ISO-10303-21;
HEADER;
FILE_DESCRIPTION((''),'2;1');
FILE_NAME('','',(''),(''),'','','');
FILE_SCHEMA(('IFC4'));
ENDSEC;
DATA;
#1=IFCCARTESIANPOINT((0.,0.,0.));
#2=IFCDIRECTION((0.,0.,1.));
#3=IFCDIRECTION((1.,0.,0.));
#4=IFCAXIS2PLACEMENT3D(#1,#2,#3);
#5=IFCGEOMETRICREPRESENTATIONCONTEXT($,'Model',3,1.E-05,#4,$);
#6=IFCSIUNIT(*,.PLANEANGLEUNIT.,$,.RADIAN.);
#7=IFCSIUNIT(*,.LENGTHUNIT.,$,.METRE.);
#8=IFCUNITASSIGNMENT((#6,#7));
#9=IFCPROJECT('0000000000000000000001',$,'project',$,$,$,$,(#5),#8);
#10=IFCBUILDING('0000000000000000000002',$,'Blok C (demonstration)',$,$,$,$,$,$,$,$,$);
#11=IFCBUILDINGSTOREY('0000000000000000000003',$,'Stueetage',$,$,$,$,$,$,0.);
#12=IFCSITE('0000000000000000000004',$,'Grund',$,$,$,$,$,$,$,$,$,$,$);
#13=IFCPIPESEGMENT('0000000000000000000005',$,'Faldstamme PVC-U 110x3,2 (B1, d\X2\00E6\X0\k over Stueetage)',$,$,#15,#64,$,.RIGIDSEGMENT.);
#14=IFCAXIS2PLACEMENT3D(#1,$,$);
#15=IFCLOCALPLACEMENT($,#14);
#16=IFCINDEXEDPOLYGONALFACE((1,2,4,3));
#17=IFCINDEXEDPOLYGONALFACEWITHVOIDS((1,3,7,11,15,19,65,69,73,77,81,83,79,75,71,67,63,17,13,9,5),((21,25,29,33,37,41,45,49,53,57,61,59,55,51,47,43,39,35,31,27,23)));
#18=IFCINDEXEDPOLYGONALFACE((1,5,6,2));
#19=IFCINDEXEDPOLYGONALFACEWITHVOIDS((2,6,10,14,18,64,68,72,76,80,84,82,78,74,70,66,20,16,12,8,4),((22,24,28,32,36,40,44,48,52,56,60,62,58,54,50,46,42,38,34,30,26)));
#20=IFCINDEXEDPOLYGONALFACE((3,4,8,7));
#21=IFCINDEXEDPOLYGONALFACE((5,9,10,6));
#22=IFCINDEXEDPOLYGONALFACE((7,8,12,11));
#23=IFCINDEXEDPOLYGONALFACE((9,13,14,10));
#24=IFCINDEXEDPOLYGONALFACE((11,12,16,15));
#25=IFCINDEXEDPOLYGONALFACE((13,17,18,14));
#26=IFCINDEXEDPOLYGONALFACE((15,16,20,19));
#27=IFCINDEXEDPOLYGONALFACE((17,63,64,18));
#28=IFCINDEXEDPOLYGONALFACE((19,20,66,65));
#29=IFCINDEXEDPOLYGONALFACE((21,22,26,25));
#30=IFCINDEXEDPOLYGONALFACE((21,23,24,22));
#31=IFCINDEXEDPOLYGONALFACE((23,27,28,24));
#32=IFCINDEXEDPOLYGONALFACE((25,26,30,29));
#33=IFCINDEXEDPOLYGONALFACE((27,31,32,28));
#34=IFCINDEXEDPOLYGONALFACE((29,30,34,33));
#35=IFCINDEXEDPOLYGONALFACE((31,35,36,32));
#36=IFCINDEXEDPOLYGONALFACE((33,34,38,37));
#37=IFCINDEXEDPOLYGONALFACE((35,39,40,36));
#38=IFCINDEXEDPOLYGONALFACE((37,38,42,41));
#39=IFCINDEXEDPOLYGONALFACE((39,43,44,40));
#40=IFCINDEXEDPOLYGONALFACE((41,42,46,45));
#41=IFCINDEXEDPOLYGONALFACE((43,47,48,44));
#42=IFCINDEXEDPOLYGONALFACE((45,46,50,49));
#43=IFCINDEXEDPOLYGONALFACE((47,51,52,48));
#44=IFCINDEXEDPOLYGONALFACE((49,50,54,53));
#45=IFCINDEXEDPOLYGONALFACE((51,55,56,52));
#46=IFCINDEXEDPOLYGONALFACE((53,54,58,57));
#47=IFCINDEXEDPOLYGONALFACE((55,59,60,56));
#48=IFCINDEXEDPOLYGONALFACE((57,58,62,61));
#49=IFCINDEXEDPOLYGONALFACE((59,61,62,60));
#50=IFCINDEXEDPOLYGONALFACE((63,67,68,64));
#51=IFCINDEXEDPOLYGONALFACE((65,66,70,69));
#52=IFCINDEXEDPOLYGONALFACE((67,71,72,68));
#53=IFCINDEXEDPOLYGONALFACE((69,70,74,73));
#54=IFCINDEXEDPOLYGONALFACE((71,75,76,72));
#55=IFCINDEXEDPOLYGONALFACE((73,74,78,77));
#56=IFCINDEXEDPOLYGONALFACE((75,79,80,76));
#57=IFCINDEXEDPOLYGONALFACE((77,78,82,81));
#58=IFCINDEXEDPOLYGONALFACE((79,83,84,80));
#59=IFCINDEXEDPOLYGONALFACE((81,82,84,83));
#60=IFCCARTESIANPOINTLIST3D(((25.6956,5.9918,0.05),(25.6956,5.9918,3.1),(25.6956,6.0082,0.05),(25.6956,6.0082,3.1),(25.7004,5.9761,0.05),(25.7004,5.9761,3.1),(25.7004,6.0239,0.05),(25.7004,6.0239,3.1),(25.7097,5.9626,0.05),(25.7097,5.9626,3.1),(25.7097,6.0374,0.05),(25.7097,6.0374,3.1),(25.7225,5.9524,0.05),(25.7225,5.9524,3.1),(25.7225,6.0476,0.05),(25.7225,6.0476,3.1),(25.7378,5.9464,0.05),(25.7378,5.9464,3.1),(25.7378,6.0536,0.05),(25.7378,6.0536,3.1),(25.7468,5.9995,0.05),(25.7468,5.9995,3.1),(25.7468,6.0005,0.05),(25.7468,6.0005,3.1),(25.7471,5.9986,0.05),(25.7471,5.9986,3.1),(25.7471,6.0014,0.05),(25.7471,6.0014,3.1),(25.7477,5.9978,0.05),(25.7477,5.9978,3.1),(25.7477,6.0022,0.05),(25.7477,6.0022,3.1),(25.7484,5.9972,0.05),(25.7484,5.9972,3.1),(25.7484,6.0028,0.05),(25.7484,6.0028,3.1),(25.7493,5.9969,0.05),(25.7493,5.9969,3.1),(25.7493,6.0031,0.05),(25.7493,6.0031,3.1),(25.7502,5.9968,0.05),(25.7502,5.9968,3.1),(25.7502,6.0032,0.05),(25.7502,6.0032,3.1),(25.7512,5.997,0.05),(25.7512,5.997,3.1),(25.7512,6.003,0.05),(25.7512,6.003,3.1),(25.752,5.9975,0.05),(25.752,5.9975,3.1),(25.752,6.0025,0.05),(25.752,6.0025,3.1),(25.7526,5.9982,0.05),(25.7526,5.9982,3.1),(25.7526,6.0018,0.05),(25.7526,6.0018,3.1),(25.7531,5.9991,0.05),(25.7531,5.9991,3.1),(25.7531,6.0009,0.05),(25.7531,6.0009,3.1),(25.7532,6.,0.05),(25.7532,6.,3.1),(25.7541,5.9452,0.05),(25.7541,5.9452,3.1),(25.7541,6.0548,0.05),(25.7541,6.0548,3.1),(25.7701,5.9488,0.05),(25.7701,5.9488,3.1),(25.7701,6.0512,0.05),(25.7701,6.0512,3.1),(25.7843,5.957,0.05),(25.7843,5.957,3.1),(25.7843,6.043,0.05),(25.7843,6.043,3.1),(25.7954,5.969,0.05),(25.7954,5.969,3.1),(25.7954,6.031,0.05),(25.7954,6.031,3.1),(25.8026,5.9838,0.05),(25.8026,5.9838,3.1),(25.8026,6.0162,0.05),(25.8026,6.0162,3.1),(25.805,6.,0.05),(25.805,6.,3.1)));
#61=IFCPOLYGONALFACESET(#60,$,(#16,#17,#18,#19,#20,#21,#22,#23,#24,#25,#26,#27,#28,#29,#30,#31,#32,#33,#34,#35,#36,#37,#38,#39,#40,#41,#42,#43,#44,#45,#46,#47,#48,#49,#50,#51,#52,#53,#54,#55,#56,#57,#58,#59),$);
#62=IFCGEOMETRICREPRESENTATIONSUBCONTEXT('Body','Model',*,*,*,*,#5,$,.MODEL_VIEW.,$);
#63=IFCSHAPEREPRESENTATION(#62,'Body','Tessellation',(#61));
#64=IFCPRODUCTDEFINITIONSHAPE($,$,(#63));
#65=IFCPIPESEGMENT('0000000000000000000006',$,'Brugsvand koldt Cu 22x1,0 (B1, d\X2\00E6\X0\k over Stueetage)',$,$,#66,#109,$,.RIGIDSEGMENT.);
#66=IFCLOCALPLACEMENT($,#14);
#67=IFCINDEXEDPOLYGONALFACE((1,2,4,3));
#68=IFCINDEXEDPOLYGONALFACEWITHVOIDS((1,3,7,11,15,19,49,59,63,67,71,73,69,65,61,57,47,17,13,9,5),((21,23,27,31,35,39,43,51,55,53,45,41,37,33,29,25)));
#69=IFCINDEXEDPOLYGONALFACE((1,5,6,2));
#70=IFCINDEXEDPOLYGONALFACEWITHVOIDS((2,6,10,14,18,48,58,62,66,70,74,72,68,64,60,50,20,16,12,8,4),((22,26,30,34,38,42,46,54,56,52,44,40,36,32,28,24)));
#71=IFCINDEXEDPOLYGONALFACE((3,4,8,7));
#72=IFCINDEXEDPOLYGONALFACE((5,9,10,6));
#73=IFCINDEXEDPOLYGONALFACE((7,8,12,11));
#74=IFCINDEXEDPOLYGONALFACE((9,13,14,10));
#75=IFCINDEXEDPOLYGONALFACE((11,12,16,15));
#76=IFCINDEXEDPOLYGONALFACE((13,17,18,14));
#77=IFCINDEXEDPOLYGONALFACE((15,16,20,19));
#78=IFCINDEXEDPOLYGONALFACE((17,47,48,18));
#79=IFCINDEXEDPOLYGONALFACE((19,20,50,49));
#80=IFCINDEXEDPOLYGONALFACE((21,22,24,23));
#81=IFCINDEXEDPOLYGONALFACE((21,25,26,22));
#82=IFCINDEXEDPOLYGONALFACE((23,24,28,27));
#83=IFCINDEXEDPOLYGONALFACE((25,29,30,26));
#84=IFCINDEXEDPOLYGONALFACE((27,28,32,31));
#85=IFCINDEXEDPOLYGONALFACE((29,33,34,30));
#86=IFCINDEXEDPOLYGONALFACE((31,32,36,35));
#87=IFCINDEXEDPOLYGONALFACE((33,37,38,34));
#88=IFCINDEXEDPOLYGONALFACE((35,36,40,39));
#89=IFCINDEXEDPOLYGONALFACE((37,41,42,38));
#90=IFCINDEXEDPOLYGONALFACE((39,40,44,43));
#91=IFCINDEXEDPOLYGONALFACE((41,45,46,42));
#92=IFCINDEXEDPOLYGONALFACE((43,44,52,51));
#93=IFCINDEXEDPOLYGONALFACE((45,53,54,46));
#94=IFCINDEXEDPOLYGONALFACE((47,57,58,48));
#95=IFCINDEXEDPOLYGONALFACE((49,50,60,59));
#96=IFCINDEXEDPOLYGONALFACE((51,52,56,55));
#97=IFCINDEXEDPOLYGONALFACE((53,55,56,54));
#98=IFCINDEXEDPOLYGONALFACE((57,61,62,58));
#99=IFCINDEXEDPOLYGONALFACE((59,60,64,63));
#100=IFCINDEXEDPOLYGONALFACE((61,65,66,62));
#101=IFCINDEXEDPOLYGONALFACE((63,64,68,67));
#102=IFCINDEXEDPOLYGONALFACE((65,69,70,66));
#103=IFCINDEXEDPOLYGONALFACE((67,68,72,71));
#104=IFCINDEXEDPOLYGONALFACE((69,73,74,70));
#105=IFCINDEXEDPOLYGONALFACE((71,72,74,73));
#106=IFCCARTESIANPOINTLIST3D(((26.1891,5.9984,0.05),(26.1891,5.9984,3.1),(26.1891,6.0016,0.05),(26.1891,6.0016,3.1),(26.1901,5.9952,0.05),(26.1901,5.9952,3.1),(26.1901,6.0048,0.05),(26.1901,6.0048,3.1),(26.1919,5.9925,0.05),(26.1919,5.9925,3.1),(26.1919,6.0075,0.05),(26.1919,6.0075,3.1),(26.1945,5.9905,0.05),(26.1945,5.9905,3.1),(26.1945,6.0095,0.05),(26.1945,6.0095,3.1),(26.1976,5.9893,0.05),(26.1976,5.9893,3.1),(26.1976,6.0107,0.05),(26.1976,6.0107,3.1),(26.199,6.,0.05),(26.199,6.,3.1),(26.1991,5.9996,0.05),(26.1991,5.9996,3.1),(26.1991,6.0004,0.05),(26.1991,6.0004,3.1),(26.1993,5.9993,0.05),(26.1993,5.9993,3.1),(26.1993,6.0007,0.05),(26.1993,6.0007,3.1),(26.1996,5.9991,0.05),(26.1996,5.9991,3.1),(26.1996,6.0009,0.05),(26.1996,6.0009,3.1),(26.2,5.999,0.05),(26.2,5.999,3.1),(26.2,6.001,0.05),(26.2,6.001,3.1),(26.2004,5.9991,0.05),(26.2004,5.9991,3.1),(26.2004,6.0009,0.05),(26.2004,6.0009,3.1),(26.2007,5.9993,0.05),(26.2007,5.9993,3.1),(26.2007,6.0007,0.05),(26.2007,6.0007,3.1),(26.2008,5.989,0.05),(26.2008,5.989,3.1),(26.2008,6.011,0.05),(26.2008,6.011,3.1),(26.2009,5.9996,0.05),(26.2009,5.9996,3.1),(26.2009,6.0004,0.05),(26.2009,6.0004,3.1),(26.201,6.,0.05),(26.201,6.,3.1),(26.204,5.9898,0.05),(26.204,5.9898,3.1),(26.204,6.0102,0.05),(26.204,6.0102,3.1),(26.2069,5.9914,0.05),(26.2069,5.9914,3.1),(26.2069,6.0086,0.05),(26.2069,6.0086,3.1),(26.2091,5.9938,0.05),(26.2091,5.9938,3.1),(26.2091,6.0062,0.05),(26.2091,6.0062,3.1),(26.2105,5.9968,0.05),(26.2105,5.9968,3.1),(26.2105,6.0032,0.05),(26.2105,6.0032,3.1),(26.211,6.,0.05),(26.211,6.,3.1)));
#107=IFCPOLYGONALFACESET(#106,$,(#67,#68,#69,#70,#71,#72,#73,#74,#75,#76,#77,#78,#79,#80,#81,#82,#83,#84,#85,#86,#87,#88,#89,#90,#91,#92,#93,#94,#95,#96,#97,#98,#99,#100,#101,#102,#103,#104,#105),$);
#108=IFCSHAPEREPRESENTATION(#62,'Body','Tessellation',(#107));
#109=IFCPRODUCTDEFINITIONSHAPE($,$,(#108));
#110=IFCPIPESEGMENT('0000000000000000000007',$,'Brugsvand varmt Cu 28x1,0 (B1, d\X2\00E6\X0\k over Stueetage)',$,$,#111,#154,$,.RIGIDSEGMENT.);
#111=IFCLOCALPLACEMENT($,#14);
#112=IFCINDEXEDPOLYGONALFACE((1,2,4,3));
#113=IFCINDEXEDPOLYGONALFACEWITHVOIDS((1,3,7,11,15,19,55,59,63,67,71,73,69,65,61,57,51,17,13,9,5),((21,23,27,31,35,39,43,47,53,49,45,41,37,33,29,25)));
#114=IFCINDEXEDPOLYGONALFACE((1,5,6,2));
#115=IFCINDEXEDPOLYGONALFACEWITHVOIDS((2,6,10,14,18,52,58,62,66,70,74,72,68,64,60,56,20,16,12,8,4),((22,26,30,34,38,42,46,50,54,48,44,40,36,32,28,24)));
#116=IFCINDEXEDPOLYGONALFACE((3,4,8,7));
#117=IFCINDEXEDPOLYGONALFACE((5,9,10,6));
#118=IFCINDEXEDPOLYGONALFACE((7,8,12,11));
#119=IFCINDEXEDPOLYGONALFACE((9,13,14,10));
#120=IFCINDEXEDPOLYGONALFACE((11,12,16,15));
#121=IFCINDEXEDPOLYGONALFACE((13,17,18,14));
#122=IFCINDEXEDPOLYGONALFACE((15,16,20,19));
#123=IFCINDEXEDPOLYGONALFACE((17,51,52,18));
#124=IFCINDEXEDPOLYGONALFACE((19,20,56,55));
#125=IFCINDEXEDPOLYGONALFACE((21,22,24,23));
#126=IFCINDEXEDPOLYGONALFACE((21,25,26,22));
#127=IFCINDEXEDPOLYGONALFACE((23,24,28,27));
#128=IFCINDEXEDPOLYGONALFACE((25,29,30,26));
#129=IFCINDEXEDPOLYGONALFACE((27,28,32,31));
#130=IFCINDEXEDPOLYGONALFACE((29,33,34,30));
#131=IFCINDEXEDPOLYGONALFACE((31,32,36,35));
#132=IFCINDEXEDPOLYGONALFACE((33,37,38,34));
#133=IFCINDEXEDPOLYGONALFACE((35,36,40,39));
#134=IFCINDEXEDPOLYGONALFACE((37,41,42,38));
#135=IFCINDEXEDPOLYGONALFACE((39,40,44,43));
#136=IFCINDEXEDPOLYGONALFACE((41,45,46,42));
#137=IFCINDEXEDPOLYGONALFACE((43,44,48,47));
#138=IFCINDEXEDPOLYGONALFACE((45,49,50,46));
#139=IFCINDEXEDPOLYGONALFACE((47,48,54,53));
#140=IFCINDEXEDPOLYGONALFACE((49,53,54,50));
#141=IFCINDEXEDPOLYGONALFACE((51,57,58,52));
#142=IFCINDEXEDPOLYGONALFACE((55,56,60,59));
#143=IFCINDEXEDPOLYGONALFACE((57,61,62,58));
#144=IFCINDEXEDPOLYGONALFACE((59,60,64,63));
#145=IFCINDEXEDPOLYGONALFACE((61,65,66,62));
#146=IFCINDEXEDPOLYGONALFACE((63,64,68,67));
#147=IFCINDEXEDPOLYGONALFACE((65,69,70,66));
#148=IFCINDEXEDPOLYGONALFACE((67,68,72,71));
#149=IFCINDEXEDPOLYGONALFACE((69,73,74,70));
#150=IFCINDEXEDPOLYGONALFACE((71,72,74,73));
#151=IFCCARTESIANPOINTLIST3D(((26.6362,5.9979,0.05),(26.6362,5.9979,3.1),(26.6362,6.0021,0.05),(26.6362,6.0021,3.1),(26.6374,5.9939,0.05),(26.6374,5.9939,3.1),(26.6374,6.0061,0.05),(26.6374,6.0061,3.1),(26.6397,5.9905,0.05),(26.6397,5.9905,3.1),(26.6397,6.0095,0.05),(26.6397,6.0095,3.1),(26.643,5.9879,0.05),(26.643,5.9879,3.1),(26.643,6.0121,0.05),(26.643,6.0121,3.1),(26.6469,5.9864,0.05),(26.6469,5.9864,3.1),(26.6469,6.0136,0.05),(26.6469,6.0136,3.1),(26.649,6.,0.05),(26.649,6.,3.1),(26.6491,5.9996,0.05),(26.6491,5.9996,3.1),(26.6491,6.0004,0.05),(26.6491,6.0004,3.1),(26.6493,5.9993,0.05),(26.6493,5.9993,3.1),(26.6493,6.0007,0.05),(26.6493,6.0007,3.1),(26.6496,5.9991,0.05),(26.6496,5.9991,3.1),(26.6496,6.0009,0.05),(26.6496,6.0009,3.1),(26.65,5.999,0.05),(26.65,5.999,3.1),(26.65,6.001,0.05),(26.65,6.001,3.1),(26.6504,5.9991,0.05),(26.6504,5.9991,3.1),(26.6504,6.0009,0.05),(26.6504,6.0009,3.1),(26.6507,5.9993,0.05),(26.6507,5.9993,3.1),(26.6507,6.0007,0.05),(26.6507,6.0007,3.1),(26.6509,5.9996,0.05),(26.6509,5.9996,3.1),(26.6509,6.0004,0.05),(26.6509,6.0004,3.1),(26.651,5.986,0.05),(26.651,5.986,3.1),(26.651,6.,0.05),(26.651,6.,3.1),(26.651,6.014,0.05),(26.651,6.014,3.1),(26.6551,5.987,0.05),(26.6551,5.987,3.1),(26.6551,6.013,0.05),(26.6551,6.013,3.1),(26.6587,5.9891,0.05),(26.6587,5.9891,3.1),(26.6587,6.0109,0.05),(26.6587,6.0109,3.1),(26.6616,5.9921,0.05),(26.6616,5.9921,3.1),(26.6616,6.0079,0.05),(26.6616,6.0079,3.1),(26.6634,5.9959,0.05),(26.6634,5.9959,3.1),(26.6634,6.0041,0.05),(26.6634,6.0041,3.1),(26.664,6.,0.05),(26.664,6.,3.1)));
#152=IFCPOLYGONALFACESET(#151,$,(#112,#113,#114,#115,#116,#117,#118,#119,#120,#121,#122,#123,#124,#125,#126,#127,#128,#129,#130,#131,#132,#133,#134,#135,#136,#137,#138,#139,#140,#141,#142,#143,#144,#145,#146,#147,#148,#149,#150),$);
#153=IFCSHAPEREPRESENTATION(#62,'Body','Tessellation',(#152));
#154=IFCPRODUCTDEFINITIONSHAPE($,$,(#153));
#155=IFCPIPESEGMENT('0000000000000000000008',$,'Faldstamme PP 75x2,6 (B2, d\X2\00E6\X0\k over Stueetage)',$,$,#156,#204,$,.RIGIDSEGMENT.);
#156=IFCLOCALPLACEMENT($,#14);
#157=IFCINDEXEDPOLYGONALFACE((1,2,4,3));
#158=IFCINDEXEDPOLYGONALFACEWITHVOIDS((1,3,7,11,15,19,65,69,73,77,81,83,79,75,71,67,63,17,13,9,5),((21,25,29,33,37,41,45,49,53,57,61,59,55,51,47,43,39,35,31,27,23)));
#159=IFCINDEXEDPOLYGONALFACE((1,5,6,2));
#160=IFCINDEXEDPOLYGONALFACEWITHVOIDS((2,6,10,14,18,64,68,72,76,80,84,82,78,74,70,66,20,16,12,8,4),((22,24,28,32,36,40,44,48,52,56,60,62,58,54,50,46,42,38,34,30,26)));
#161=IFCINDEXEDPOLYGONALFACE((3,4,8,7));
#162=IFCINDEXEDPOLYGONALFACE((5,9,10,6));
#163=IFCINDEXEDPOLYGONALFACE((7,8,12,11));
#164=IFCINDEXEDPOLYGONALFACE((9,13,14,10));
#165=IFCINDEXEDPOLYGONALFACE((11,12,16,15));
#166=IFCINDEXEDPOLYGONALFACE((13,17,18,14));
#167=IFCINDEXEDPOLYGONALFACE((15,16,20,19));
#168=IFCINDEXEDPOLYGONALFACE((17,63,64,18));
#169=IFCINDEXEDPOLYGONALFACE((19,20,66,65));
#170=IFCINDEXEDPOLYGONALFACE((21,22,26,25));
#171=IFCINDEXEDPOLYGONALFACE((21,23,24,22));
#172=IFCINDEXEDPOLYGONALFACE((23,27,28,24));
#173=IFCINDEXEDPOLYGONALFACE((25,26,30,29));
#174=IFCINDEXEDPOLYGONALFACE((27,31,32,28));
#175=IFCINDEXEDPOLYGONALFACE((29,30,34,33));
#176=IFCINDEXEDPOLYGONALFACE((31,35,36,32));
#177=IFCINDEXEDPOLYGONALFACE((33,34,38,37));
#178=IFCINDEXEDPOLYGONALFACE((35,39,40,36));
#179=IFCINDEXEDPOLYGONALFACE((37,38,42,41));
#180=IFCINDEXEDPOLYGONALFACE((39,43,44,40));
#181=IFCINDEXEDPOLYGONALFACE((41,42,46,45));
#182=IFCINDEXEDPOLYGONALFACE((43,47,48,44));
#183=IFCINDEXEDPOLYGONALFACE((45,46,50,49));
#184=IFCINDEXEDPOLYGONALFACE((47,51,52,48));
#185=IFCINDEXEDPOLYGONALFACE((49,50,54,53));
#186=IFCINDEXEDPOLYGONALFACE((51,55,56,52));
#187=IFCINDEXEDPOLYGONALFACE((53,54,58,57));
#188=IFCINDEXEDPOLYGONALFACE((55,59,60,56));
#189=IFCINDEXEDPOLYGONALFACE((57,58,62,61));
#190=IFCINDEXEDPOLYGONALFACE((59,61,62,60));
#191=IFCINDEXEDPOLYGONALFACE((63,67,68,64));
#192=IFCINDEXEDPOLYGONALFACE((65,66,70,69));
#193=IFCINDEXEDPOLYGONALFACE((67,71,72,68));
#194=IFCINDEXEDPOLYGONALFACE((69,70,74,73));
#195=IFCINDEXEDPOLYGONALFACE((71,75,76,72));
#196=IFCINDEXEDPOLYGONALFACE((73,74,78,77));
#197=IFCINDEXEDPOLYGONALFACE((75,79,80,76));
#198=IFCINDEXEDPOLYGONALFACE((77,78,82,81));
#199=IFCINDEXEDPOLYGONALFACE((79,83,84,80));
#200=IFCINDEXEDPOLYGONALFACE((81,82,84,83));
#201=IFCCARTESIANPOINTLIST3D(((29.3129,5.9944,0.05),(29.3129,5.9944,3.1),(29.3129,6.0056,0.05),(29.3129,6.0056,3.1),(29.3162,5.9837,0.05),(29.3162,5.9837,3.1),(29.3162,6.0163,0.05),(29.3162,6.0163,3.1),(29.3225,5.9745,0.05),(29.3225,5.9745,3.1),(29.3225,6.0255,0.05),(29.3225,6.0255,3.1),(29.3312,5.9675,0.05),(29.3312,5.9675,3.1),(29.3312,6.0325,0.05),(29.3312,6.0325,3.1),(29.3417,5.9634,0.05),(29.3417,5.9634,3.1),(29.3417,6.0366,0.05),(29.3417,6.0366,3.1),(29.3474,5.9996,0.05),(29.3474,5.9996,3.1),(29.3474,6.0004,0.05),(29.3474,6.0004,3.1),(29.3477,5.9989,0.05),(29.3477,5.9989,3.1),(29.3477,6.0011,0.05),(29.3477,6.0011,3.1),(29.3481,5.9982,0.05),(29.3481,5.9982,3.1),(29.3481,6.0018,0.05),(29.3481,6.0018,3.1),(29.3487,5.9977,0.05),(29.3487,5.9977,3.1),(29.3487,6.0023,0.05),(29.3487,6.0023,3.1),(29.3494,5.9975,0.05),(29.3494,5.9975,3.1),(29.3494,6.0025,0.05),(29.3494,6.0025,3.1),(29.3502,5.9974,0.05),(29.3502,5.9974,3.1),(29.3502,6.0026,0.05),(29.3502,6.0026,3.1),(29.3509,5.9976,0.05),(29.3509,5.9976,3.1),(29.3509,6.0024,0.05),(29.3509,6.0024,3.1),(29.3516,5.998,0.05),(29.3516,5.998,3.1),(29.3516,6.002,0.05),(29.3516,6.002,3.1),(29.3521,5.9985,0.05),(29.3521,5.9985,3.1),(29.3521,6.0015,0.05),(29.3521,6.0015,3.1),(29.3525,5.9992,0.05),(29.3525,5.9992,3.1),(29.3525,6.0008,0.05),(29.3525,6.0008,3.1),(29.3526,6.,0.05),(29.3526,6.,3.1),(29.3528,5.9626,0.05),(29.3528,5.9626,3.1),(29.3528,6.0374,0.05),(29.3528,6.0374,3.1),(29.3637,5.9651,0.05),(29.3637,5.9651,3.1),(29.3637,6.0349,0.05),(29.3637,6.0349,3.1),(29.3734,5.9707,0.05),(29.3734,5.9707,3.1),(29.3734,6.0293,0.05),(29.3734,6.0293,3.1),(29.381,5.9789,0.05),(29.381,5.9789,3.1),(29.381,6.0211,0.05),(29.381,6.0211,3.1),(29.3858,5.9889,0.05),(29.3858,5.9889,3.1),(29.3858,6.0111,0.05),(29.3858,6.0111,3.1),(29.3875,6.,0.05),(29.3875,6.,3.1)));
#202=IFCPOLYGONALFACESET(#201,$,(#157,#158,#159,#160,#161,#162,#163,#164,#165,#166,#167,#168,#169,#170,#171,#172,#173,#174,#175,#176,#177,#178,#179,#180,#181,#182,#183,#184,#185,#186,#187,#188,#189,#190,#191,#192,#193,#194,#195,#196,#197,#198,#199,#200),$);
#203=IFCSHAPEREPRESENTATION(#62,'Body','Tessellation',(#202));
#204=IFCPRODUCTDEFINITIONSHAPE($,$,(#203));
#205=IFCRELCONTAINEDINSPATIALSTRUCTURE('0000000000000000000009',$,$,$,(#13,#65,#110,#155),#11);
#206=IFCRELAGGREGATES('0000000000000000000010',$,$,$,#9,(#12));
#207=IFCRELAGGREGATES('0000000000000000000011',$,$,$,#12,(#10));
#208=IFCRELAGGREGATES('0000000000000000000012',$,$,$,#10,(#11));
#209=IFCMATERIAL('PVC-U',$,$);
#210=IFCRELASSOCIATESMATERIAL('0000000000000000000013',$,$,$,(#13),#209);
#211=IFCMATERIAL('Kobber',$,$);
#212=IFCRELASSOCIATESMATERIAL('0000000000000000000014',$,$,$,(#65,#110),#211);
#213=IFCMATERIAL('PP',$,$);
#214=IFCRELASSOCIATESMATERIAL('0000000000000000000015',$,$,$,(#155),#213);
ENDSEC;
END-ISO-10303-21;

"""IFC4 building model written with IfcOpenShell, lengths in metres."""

from ifc_helpers import new_model, si_unit, frame, origin_with_axes, place, context, subcontext, project, spatial, hollow_circle, extrude, material, element, save


model = new_model("IFC4")

# Units and contexts
model_context = context("Model", 3, precision=1e-05, world=origin_with_axes())
body_context = subcontext(model_context, "Body", "Model", "MODEL_VIEW")
ifc_project = project(units=[si_unit("PLANEANGLEUNIT", "RADIAN"), si_unit("LENGTHUNIT", "METRE")], contexts=[model_context])

# Site, building, storey
site = spatial("IfcSite", under=ifc_project, Name="Grund")
building = spatial("IfcBuilding", under=site, Name="Blok C (demonstration)")
storey = spatial("IfcBuildingStorey", under=building, Name="Stueetage", Elevation=0.0)

# Pipe segments
ifc_material_1 = material(Name="PVC-U")
pipe_segment_1_placement = place(None, origin_with_axes())
element("IfcPipeSegment", 1, at=pipe_segment_1_placement, inside=storey, material=ifc_material_1, Name="Faldstamme PVC-U 110x3,2 (B1, dæk over Stueetage)", PredefinedType="RIGIDSEGMENT", context=body_context, shape_type="SweptSolid", body=[
    extrude(hollow_circle(Radius=0.055, WallThickness=0.0518), frame((25.75, 6.0, 0.05), z_axis=(0.0, 0.0, 1.0), x_axis=(1.0, 0.0, 0.0)), (0.0, 0.0, 1.0), 3.05),
])
ifc_material_2 = material(Name="Kobber")
pipe_segment_2_placement = place(None, origin_with_axes())
element("IfcPipeSegment", 2, at=pipe_segment_2_placement, inside=storey, material=ifc_material_2, Name="Brugsvand koldt Cu 22x1,0 (B1, dæk over Stueetage)", PredefinedType="RIGIDSEGMENT", context=body_context, shape_type="SweptSolid", body=[
    extrude(hollow_circle(Radius=0.011, WallThickness=0.01), frame((26.2, 6.0, 0.05), z_axis=(0.0, 0.0, 1.0), x_axis=(1.0, 0.0, 0.0)), (0.0, 0.0, 1.0), 3.05),
])
pipe_segment_3_placement = place(None, origin_with_axes())
element("IfcPipeSegment", 3, at=pipe_segment_3_placement, inside=storey, material=ifc_material_2, Name="Brugsvand varmt Cu 28x1,0 (B1, dæk over Stueetage)", PredefinedType="RIGIDSEGMENT", context=body_context, shape_type="SweptSolid", body=[
    extrude(hollow_circle(Radius=0.014, WallThickness=0.013), frame((26.65, 6.0, 0.05), z_axis=(0.0, 0.0, 1.0), x_axis=(1.0, 0.0, 0.0)), (0.0, 0.0, 1.0), 3.05),
])
ifc_material_3 = material(Name="PP")
pipe_segment_4_placement = place(None, origin_with_axes())
element("IfcPipeSegment", 4, at=pipe_segment_4_placement, inside=storey, material=ifc_material_3, Name="Faldstamme PP 75x2,6 (B2, dæk over Stueetage)", PredefinedType="RIGIDSEGMENT", context=body_context, shape_type="SweptSolid", body=[
    extrude(hollow_circle(Radius=0.0375, WallThickness=0.0349), frame((29.35, 6.0, 0.05), z_axis=(0.0, 0.0, 1.0), x_axis=(1.0, 0.0, 0.0)), (0.0, 0.0, 1.0), 3.05),
])

save(model, "model.ifc")
